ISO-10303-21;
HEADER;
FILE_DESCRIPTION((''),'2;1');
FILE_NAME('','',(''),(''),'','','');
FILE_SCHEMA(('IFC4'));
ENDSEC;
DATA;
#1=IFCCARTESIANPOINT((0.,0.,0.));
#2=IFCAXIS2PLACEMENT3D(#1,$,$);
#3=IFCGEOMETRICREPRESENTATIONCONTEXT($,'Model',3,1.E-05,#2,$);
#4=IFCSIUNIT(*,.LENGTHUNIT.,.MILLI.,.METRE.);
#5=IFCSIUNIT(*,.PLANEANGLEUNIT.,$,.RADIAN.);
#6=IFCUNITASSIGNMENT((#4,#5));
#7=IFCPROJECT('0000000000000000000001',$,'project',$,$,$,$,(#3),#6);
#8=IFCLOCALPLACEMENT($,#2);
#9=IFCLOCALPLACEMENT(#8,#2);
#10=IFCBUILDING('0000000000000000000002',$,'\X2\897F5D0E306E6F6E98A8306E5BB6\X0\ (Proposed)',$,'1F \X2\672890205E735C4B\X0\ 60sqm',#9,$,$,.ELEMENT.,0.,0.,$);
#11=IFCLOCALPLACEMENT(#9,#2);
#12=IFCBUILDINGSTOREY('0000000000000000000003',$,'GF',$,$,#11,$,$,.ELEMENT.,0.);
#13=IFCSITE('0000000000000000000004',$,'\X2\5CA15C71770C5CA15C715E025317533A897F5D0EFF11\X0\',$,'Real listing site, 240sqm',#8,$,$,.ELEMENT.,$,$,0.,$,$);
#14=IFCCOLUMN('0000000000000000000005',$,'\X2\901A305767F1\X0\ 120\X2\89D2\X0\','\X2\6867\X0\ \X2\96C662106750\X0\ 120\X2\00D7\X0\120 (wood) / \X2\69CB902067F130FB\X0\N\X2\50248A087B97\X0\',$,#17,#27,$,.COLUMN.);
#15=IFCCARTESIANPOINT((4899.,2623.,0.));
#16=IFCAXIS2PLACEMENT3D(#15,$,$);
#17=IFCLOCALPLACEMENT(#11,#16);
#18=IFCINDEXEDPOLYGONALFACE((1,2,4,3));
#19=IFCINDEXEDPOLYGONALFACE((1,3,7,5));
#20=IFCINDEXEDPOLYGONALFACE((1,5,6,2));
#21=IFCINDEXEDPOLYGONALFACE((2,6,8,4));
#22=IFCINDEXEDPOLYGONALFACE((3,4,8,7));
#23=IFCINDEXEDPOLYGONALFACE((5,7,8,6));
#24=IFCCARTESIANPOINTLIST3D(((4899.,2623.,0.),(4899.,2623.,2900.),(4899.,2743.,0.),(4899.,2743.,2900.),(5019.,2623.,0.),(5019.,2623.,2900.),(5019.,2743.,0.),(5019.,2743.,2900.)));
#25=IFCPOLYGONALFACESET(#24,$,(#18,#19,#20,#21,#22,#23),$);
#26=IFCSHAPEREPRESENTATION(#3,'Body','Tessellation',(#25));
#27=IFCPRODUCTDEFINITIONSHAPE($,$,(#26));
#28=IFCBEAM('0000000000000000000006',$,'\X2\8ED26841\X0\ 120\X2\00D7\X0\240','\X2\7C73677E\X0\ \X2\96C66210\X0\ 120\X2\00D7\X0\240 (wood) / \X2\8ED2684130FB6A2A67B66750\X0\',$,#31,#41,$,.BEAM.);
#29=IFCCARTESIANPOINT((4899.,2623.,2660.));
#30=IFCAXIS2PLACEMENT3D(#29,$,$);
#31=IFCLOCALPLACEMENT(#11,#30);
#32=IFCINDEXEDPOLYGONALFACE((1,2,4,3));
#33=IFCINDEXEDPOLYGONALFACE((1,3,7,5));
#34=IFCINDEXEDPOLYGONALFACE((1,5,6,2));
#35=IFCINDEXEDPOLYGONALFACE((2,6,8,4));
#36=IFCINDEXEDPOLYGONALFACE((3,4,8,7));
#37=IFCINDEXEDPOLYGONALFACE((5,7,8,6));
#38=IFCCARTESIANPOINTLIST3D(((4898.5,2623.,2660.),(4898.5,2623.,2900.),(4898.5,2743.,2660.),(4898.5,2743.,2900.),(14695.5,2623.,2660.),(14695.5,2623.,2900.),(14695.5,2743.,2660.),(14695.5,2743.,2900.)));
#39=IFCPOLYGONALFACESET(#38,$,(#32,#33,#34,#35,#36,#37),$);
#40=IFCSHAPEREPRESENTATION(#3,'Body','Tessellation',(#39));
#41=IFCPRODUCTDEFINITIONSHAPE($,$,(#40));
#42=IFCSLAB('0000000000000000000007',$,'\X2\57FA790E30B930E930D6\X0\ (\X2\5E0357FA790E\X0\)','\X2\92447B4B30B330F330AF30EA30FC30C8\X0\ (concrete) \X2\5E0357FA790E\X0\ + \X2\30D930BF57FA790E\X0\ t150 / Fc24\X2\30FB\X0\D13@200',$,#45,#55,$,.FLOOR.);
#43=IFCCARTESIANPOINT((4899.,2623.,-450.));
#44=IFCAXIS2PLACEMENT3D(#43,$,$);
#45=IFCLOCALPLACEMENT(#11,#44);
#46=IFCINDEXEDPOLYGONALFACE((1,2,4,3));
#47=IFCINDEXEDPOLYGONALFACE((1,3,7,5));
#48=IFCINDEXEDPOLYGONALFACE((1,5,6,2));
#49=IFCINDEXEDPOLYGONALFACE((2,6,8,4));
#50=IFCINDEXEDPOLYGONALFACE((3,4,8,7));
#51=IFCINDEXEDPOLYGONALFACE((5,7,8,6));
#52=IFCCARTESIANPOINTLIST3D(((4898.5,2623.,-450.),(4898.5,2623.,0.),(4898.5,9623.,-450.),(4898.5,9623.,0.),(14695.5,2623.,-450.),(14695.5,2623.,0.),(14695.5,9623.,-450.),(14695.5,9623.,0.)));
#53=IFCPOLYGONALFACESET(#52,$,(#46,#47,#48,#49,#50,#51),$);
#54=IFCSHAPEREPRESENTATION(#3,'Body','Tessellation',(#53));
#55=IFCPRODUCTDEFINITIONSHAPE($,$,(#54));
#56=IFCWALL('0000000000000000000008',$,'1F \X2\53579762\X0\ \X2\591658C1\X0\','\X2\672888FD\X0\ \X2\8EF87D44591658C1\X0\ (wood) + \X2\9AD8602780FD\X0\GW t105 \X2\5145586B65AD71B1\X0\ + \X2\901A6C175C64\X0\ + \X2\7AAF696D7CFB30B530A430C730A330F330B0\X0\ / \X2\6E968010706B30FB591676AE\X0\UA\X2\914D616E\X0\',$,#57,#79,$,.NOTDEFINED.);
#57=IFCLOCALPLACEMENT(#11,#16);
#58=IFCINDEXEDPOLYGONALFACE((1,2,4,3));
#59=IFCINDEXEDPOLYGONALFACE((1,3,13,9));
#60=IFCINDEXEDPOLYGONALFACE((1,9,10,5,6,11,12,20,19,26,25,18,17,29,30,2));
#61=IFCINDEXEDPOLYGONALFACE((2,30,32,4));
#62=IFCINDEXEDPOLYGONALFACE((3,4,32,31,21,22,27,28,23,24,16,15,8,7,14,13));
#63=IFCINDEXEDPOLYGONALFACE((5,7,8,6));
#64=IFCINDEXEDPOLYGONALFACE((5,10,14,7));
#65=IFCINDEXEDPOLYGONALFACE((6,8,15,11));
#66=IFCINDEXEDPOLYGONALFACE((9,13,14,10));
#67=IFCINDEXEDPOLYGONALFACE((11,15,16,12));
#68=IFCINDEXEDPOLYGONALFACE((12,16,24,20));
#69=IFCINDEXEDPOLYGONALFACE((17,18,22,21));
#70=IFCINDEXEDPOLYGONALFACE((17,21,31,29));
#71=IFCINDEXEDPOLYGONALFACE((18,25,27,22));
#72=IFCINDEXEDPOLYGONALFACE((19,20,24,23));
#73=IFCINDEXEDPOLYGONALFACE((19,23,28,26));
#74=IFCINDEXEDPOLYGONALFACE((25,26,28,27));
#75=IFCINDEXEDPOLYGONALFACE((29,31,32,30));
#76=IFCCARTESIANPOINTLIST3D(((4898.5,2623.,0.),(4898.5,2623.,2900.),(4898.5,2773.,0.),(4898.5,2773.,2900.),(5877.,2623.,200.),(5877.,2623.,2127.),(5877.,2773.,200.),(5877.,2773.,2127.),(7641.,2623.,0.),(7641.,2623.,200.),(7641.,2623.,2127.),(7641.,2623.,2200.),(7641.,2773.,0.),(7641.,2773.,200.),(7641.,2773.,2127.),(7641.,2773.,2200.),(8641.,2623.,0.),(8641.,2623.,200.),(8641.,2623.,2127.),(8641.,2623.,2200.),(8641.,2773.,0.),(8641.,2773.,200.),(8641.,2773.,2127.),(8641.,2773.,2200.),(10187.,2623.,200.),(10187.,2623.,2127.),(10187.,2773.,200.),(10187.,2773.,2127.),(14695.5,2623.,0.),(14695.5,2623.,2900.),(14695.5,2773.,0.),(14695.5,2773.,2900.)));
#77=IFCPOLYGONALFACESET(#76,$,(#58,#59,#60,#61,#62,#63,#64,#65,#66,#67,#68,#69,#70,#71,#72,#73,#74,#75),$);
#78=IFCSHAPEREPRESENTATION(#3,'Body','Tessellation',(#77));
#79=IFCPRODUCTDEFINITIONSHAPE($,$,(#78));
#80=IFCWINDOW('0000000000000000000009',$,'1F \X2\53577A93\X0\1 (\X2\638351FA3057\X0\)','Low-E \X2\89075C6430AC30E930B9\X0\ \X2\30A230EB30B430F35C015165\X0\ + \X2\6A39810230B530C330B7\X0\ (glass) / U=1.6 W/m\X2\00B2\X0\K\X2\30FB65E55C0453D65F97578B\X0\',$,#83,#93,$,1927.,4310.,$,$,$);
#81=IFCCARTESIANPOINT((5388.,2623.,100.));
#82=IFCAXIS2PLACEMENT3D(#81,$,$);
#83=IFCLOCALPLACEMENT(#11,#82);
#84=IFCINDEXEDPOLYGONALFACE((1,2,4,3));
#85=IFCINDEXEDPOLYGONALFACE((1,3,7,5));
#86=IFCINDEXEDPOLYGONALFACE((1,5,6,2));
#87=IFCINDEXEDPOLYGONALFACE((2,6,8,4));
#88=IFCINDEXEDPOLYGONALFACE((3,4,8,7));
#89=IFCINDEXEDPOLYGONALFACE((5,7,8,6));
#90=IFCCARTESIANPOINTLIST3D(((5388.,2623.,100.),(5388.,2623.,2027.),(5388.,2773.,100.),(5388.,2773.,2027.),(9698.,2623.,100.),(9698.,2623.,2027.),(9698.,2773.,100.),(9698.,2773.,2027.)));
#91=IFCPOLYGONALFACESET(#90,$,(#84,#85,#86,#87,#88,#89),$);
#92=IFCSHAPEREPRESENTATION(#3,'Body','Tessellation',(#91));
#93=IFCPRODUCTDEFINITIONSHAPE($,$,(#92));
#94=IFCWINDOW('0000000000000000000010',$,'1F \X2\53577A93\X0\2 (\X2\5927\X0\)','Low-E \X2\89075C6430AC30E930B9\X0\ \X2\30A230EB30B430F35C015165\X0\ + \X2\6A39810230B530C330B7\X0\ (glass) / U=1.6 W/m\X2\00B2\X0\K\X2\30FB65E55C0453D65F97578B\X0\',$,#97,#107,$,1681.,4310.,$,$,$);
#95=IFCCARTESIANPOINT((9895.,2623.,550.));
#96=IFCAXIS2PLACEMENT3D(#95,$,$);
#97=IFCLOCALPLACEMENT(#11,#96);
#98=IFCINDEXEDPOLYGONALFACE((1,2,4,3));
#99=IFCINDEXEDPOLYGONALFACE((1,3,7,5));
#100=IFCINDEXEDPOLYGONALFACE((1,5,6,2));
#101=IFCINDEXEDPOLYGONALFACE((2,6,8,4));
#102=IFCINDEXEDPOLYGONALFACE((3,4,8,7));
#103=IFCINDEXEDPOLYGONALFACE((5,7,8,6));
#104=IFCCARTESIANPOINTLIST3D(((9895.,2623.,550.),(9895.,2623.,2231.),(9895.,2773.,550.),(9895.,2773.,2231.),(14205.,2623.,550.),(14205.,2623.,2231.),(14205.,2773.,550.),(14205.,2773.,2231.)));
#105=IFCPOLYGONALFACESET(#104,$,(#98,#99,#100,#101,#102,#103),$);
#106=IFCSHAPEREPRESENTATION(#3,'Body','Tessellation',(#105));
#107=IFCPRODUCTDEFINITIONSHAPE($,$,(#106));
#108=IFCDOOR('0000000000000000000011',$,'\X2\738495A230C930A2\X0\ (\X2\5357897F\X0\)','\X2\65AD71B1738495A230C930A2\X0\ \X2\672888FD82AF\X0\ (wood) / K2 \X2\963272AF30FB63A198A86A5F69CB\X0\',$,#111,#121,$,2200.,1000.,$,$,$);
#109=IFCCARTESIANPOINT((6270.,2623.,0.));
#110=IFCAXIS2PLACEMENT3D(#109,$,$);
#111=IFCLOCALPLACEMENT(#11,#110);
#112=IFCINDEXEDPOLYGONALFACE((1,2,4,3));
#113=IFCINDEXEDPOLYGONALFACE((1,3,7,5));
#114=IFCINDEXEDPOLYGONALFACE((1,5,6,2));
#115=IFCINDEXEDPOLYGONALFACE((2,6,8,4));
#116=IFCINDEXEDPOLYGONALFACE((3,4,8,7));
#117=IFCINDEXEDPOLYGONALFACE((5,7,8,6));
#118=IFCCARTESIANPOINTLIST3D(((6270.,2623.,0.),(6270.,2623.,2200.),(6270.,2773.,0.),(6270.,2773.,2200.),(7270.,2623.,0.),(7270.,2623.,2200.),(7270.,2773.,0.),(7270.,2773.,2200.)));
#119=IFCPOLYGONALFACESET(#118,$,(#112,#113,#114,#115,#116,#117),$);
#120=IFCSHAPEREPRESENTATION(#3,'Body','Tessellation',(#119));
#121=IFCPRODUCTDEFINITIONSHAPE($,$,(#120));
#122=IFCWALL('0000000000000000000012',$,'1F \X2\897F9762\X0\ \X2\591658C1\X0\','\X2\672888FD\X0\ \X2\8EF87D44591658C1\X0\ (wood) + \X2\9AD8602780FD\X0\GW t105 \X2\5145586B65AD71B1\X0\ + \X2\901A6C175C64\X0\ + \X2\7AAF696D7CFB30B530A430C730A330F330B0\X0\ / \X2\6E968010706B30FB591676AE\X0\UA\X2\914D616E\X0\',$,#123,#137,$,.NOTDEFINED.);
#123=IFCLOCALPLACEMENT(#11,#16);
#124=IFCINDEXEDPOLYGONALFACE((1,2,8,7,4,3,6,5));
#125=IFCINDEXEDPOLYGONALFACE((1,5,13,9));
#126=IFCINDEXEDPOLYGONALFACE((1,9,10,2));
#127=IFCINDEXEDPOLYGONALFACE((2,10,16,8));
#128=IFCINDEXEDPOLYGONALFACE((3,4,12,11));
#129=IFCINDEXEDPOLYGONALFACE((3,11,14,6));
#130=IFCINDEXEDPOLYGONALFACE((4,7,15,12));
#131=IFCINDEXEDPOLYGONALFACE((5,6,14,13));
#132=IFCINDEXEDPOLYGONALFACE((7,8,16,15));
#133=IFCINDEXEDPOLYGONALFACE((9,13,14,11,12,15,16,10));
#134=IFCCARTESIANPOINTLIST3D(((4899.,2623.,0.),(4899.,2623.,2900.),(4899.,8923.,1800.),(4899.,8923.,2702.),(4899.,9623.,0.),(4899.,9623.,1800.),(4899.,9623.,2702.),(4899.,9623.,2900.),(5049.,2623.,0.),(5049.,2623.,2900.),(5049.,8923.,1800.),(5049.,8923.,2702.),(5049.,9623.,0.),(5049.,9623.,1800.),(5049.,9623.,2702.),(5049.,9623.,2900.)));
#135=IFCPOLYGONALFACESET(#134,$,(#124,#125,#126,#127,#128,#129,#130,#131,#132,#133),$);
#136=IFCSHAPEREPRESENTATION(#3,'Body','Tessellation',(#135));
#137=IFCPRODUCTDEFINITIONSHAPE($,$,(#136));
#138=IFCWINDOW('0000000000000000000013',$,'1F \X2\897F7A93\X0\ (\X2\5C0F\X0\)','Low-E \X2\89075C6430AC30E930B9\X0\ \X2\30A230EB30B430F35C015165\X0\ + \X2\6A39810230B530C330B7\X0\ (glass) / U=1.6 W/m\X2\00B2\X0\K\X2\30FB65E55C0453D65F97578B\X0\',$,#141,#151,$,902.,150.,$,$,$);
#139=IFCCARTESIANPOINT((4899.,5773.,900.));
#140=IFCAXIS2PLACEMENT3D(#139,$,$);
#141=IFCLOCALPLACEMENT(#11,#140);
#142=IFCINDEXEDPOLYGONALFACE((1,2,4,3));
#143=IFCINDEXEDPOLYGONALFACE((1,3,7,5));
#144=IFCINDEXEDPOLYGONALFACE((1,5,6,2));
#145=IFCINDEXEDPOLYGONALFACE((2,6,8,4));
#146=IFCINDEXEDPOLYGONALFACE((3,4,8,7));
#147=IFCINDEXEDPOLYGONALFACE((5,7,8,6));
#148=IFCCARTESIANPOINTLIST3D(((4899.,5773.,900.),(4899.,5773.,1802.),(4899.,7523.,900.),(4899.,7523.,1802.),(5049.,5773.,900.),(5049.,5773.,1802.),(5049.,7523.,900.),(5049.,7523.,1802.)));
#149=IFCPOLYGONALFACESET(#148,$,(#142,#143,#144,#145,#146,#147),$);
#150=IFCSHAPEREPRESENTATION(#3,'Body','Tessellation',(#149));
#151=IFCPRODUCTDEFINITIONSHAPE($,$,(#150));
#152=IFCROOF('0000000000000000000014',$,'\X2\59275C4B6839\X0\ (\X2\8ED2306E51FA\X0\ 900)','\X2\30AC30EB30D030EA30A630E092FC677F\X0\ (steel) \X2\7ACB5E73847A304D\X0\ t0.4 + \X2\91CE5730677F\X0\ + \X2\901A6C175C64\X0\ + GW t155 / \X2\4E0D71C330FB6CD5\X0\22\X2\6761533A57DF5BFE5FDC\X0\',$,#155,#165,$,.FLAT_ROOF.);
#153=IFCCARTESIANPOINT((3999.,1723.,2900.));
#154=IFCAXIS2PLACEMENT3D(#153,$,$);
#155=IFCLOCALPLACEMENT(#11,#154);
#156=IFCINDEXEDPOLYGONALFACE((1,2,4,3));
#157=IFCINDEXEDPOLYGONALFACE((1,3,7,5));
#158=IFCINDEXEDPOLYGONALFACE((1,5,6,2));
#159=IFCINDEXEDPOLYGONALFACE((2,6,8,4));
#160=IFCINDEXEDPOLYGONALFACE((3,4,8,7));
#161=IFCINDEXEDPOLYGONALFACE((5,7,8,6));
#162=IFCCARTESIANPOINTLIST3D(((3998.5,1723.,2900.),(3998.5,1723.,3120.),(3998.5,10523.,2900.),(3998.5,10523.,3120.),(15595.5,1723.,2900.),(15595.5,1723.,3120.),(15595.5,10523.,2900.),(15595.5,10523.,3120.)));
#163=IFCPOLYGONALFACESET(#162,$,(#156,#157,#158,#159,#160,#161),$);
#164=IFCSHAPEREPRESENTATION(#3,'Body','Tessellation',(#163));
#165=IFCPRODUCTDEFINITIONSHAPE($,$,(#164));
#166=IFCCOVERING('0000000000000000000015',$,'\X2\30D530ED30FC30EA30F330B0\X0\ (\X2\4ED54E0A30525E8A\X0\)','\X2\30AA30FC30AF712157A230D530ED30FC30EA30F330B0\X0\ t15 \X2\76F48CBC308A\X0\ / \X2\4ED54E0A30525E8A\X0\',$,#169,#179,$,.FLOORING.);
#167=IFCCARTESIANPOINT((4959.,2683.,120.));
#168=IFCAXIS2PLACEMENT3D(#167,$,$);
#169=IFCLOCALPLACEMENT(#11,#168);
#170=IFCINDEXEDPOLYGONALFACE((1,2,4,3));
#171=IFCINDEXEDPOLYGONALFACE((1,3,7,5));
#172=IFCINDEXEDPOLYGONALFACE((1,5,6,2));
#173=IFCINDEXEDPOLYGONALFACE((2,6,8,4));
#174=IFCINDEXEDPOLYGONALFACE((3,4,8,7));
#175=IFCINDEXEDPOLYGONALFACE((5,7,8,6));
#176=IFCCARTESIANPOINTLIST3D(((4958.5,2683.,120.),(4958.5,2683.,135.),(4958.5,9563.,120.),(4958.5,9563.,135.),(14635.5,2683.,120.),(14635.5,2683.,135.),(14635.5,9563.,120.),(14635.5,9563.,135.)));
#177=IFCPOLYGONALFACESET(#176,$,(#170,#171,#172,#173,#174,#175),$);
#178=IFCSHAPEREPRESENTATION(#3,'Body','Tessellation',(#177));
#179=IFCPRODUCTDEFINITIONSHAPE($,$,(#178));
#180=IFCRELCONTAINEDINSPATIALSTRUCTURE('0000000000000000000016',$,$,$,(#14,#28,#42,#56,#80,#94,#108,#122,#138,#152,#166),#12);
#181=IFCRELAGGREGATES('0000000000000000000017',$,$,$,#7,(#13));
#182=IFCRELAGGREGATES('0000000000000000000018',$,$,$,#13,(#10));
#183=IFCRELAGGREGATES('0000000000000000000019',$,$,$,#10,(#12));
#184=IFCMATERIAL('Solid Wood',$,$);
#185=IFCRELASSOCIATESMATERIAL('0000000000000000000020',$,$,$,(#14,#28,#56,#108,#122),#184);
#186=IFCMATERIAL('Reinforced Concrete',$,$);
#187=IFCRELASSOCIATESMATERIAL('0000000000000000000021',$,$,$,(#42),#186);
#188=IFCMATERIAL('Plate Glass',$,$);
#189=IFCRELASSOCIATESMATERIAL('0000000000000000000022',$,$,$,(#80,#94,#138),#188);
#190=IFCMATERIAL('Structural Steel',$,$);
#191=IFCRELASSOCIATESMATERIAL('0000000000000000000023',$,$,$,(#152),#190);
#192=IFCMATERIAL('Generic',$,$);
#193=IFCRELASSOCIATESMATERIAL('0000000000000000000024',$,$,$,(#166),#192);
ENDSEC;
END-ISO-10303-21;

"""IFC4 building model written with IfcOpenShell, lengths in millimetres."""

from ifc_helpers import new_model, si_unit, frame, frame_2d, origin, place, context, project, spatial, rectangle, extrude, material, element, fill, save


model = new_model("IFC4")

# Units and contexts
model_context = context("Model", 3, precision=1e-05, world=origin())
ifc_project = project(units=[si_unit("LENGTHUNIT", "METRE", prefix="MILLI"), si_unit("PLANEANGLEUNIT", "RADIAN")], contexts=[model_context])

# Site, building, storey
site_placement = place(None, origin())
site = spatial("IfcSite", under=ifc_project, at=site_placement, Name="岡山県岡山市北区西崎１", ObjectType="Real listing site, 240sqm", CompositionType="ELEMENT", RefElevation=0.0)
building_placement = place(site_placement, origin())
building = spatial("IfcBuilding", under=site, at=building_placement, Name="西崎の潮風の家 (Proposed)", ObjectType="1F 木造平屋 60sqm", CompositionType="ELEMENT", ElevationOfRefHeight=0.0, ElevationOfTerrain=0.0)
storey_placement = place(building_placement, origin())
storey = spatial("IfcBuildingStorey", under=building, at=storey_placement, Name="GF", CompositionType="ELEMENT", Elevation=0.0)

# Column
ifc_material_1 = material(Name="Solid Wood")
column_1_placement = place(storey_placement, frame((4899.0, 2623.0, 0.0)))
element("IfcColumn", 1, at=column_1_placement, inside=storey, material=ifc_material_1, Name="通し柱 120角", Description="桧 集成材 120×120 (wood) / 構造柱・N値計算", PredefinedType="COLUMN", context=model_context, shape_type="SweptSolid", body=[
    extrude(rectangle(XDim=120.0, YDim=120.0, at=frame_2d((60.0, 60.0))), frame((4899.0, 2623.0, 0.0)), (0.0, 0.0, 1.0), 2900.0),
])

# Beam
beam_1_placement = place(storey_placement, frame((4899.0, 2623.0, 2660.0)))
element("IfcBeam", 2, at=beam_1_placement, inside=storey, material=ifc_material_1, Name="軒桁 120×240", Description="米松 集成 120×240 (wood) / 軒桁・横架材", PredefinedType="BEAM", context=model_context, shape_type="SweptSolid", body=[
    extrude(rectangle(XDim=9797.0, YDim=120.0, at=frame_2d((4898.0, 60.0))), frame((4899.0, 2623.0, 2660.0)), (0.0, 0.0, 1.0), 240.0),
])

# Slab
ifc_material_2 = material(Name="Reinforced Concrete")
slab_1_placement = place(storey_placement, frame((4899.0, 2623.0, -450.0)))
element("IfcSlab", 3, at=slab_1_placement, inside=storey, material=ifc_material_2, Name="基礎スラブ (布基礎)", Description="鉄筋コンクリート (concrete) 布基礎 + ベタ基礎 t150 / Fc24・D13@200", PredefinedType="FLOOR", context=model_context, shape_type="SweptSolid", body=[
    extrude(rectangle(XDim=9797.0, YDim=7000.0, at=frame_2d((4898.0, 3500.0))), frame((4899.0, 2623.0, -450.0)), (0.0, 0.0, 1.0), 450.0),
])

# Wall, openings, windows, door
wall_1_placement = place(storey_placement, frame((4899.0, 2623.0, 0.0)))
wall_1 = element("IfcWall", 4, at=wall_1_placement, inside=storey, material=ifc_material_1, Name="1F 南面 外壁", Description="木製 軸組外壁 (wood) + 高性能GW t105 充填断熱 + 通気層 + 窯業系サイディング / 準耐火・外皮UA配慮", PredefinedType="NOTDEFINED", context=model_context, shape_type="SweptSolid", body=[
    extrude(rectangle(XDim=9797.0, YDim=150.0, at=frame_2d((4898.0, 75.0))), frame((4899.0, 2623.0, 0.0)), (0.0, 0.0, 1.0), 2900.0),
])
opening_1_placement = place(storey_placement, frame((5388.0, 2623.0, 100.0)))
opening_1 = element("IfcOpeningElement", 5, at=opening_1_placement, cuts=wall_1, PredefinedType="NOTDEFINED", context=model_context, shape_type="SweptSolid", body=[
    extrude(rectangle(XDim=4310.0, YDim=150.0, at=frame_2d((2155.0, 75.0))), frame((5388.0, 2623.0, 100.0)), (0.0, 0.0, 1.0), 1927.0),
])
opening_2_placement = place(storey_placement, frame((9895.0, 2623.0, 550.0)))
opening_2 = element("IfcOpeningElement", 6, at=opening_2_placement, cuts=wall_1, PredefinedType="NOTDEFINED", context=model_context, shape_type="SweptSolid", body=[
    extrude(rectangle(XDim=4310.0, YDim=150.0, at=frame_2d((2155.0, 75.0))), frame((9895.0, 2623.0, 550.0)), (0.0, 0.0, 1.0), 1681.0),
])
opening_3_placement = place(storey_placement, frame((6270.0, 2623.0, 0.0)))
opening_3 = element("IfcOpeningElement", 7, at=opening_3_placement, cuts=wall_1, PredefinedType="NOTDEFINED", context=model_context, shape_type="SweptSolid", body=[
    extrude(rectangle(XDim=1000.0, YDim=150.0, at=frame_2d((500.0, 75.0))), frame((6270.0, 2623.0, 0.0)), (0.0, 0.0, 1.0), 2200.0),
])
ifc_material_3 = material(Name="Plate Glass")
window_1_placement = place(storey_placement, frame((5388.0, 2623.0, 100.0)))
window_1 = element("IfcWindow", 8, at=window_1_placement, inside=storey, material=ifc_material_3, Name="1F 南窓1 (掃出し)", Description="Low-E 複層ガラス アルゴン封入 + 樹脂サッシ (glass) / U=1.6 W/m²K・日射取得型", OverallHeight=1927.0, OverallWidth=4310.0, context=model_context, shape_type="SweptSolid", body=[
    extrude(rectangle(XDim=4310.0, YDim=150.0, at=frame_2d((2155.0, 75.0))), frame((5388.0, 2623.0, 100.0)), (0.0, 0.0, 1.0), 1927.0),
])
fill(opening_1, window_1)
window_2_placement = place(storey_placement, frame((9895.0, 2623.0, 550.0)))
window_2 = element("IfcWindow", 9, at=window_2_placement, inside=storey, material=ifc_material_3, Name="1F 南窓2 (大)", Description="Low-E 複層ガラス アルゴン封入 + 樹脂サッシ (glass) / U=1.6 W/m²K・日射取得型", OverallHeight=1681.0, OverallWidth=4310.0, context=model_context, shape_type="SweptSolid", body=[
    extrude(rectangle(XDim=4310.0, YDim=150.0, at=frame_2d((2155.0, 75.0))), frame((9895.0, 2623.0, 550.0)), (0.0, 0.0, 1.0), 1681.0),
])
fill(opening_2, window_2)
door_placement = place(storey_placement, frame((6270.0, 2623.0, 0.0)))
door = element("IfcDoor", 10, at=door_placement, inside=storey, material=ifc_material_1, Name="玄関ドア (南西)", Description="断熱玄関ドア 木製芯 (wood) / K2 防犯・採風機構", OverallHeight=2200.0, OverallWidth=1000.0, context=model_context, shape_type="SweptSolid", body=[
    extrude(rectangle(XDim=1000.0, YDim=150.0, at=frame_2d((500.0, 75.0))), frame((6270.0, 2623.0, 0.0)), (0.0, 0.0, 1.0), 2200.0),
])
fill(opening_3, door)

# Wall, opening, window
wall_2_placement = place(storey_placement, frame((4899.0, 2623.0, 0.0)))
wall_2 = element("IfcWall", 11, at=wall_2_placement, inside=storey, material=ifc_material_1, Name="1F 西面 外壁", Description="木製 軸組外壁 (wood) + 高性能GW t105 充填断熱 + 通気層 + 窯業系サイディング / 準耐火・外皮UA配慮", PredefinedType="NOTDEFINED", context=model_context, shape_type="SweptSolid", body=[
    extrude(rectangle(XDim=150.0, YDim=7000.0, at=frame_2d((75.0, 3500.0))), frame((4899.0, 2623.0, 0.0)), (0.0, 0.0, 1.0), 2900.0),
])
opening_4_placement = place(storey_placement, frame((4899.0, 5773.0, 900.0)))
opening_4 = element("IfcOpeningElement", 12, at=opening_4_placement, cuts=wall_2, PredefinedType="NOTDEFINED", context=model_context, shape_type="SweptSolid", body=[
    extrude(rectangle(XDim=150.0, YDim=1750.0, at=frame_2d((75.0, 875.0))), frame((4899.0, 5773.0, 900.0)), (0.0, 0.0, 1.0), 902.0),
])
window_3_placement = place(storey_placement, frame((4899.0, 5773.0, 900.0)))
window_3 = element("IfcWindow", 13, at=window_3_placement, inside=storey, material=ifc_material_3, Name="1F 西窓 (小)", Description="Low-E 複層ガラス アルゴン封入 + 樹脂サッシ (glass) / U=1.6 W/m²K・日射取得型", OverallHeight=902.0, OverallWidth=150.0, context=model_context, shape_type="SweptSolid", body=[
    extrude(rectangle(XDim=150.0, YDim=1750.0, at=frame_2d((75.0, 875.0))), frame((4899.0, 5773.0, 900.0)), (0.0, 0.0, 1.0), 902.0),
])
fill(opening_4, window_3)

# Roof
ifc_material_4 = material(Name="Structural Steel")
roof_placement = place(storey_placement, frame((3999.0, 1723.0, 2900.0)))
element("IfcRoof", 14, at=roof_placement, inside=storey, material=ifc_material_4, Name="大屋根 (軒の出 900)", Description="ガルバリウム鋼板 (steel) 立平葺き t0.4 + 野地板 + 通気層 + GW t155 / 不燃・法22条区域対応", PredefinedType="FLAT_ROOF", context=model_context, shape_type="SweptSolid", body=[
    extrude(rectangle(XDim=11597.0, YDim=8800.0, at=frame_2d((5798.0, 4400.0))), frame((3999.0, 1723.0, 2900.0)), (0.0, 0.0, 1.0), 220.0),
])

# Covering
ifc_material_5 = material(Name="Generic")
covering_1_placement = place(storey_placement, frame((4959.0, 2683.0, 120.0)))
element("IfcCovering", 15, at=covering_1_placement, inside=storey, material=ifc_material_5, Name="フローリング (仕上げ床)", Description="オーク無垢フローリング t15 直貼り / 仕上げ床", PredefinedType="FLOORING", context=model_context, shape_type="SweptSolid", body=[
    extrude(rectangle(XDim=9677.0, YDim=6880.0, at=frame_2d((4838.0, 3440.0))), frame((4959.0, 2683.0, 120.0)), (0.0, 0.0, 1.0), 15.0),
])

save(model, "model.ifc")
